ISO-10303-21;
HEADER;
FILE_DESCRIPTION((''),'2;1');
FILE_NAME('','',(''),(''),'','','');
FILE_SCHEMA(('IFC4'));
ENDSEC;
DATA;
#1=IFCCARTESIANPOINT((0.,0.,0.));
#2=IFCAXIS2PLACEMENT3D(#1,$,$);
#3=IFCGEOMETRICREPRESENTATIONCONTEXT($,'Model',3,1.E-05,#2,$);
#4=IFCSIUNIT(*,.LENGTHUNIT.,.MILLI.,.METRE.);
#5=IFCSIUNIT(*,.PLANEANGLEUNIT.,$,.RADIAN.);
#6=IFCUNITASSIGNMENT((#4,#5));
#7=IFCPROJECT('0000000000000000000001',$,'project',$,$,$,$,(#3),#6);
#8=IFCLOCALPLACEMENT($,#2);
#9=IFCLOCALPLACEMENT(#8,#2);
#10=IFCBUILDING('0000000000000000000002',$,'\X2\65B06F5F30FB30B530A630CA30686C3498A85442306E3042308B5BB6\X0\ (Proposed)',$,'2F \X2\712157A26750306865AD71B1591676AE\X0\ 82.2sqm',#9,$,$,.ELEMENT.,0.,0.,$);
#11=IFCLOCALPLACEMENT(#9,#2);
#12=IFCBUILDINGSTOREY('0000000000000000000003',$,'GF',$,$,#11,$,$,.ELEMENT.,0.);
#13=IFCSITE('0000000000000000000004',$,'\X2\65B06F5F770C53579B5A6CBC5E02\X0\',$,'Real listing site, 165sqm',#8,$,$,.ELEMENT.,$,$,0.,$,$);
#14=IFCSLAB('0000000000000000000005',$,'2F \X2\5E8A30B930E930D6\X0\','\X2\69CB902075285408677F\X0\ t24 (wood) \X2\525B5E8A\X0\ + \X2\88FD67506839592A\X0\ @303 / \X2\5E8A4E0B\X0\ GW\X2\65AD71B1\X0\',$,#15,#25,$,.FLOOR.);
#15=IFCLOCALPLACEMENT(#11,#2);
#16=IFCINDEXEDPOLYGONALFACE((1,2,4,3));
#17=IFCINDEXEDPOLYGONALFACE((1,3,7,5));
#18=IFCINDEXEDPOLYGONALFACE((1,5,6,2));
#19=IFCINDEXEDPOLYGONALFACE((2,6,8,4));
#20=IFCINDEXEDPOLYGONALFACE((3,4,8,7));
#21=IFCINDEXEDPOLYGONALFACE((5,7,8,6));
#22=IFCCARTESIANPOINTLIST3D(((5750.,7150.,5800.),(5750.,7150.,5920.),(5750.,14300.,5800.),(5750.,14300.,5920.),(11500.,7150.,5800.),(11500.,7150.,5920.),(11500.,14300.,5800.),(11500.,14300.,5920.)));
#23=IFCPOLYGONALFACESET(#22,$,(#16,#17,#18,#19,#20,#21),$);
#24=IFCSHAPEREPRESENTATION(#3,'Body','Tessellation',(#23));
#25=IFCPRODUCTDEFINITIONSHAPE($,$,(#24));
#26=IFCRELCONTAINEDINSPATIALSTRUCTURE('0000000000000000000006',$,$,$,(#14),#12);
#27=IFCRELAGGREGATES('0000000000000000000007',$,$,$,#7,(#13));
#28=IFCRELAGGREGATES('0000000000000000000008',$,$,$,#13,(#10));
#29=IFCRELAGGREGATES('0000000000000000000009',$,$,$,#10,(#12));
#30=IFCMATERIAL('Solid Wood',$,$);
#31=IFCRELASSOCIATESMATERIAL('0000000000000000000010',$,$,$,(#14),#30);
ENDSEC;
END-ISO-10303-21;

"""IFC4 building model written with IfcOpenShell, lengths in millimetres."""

from ifc_helpers import new_model, si_unit, frame, frame_2d, origin, place, context, project, spatial, rectangle, extrude, material, element, save


model = new_model("IFC4")

# Units and contexts
model_context = context("Model", 3, precision=1e-05, world=origin())
ifc_project = project(units=[si_unit("LENGTHUNIT", "METRE", prefix="MILLI"), si_unit("PLANEANGLEUNIT", "RADIAN")], contexts=[model_context])

# Site, building, storey
site_placement = place(None, origin())
site = spatial("IfcSite", under=ifc_project, at=site_placement, Name="新潟県南魚沼市", ObjectType="Real listing site, 165sqm", CompositionType="ELEMENT", RefElevation=0.0)
building_placement = place(site_placement, origin())
building = spatial("IfcBuilding", under=site, at=building_placement, Name="新潟・サウナと水風呂のある家 (Proposed)", ObjectType="2F 無垢材と断熱外皮 82.2sqm", CompositionType="ELEMENT", ElevationOfRefHeight=0.0, ElevationOfTerrain=0.0)
storey_placement = place(building_placement, origin())
storey = spatial("IfcBuildingStorey", under=building, at=storey_placement, Name="GF", CompositionType="ELEMENT", Elevation=0.0)

# Shared definitions
ifc_material_1 = material(Name="Solid Wood")

# Slab
slab_placement = place(storey_placement, frame((2875.0, 3575.0, 2900.0)))
element("IfcSlab", 1, at=slab_placement, inside=storey, material=ifc_material_1, Name="2F 床スラブ", Description="構造用合板 t24 (wood) 剛床 + 製材根太 @303 / 床下 GW断熱", PredefinedType="FLOOR", context=model_context, shape_type="SweptSolid", body=[
    extrude(rectangle(XDim=5750.0, YDim=7150.0, at=frame_2d((2875.0, 3575.0))), frame((2875.0, 3575.0, 2900.0)), (0.0, 0.0, 1.0), 120.0),
])

save(model, "model.ifc")
